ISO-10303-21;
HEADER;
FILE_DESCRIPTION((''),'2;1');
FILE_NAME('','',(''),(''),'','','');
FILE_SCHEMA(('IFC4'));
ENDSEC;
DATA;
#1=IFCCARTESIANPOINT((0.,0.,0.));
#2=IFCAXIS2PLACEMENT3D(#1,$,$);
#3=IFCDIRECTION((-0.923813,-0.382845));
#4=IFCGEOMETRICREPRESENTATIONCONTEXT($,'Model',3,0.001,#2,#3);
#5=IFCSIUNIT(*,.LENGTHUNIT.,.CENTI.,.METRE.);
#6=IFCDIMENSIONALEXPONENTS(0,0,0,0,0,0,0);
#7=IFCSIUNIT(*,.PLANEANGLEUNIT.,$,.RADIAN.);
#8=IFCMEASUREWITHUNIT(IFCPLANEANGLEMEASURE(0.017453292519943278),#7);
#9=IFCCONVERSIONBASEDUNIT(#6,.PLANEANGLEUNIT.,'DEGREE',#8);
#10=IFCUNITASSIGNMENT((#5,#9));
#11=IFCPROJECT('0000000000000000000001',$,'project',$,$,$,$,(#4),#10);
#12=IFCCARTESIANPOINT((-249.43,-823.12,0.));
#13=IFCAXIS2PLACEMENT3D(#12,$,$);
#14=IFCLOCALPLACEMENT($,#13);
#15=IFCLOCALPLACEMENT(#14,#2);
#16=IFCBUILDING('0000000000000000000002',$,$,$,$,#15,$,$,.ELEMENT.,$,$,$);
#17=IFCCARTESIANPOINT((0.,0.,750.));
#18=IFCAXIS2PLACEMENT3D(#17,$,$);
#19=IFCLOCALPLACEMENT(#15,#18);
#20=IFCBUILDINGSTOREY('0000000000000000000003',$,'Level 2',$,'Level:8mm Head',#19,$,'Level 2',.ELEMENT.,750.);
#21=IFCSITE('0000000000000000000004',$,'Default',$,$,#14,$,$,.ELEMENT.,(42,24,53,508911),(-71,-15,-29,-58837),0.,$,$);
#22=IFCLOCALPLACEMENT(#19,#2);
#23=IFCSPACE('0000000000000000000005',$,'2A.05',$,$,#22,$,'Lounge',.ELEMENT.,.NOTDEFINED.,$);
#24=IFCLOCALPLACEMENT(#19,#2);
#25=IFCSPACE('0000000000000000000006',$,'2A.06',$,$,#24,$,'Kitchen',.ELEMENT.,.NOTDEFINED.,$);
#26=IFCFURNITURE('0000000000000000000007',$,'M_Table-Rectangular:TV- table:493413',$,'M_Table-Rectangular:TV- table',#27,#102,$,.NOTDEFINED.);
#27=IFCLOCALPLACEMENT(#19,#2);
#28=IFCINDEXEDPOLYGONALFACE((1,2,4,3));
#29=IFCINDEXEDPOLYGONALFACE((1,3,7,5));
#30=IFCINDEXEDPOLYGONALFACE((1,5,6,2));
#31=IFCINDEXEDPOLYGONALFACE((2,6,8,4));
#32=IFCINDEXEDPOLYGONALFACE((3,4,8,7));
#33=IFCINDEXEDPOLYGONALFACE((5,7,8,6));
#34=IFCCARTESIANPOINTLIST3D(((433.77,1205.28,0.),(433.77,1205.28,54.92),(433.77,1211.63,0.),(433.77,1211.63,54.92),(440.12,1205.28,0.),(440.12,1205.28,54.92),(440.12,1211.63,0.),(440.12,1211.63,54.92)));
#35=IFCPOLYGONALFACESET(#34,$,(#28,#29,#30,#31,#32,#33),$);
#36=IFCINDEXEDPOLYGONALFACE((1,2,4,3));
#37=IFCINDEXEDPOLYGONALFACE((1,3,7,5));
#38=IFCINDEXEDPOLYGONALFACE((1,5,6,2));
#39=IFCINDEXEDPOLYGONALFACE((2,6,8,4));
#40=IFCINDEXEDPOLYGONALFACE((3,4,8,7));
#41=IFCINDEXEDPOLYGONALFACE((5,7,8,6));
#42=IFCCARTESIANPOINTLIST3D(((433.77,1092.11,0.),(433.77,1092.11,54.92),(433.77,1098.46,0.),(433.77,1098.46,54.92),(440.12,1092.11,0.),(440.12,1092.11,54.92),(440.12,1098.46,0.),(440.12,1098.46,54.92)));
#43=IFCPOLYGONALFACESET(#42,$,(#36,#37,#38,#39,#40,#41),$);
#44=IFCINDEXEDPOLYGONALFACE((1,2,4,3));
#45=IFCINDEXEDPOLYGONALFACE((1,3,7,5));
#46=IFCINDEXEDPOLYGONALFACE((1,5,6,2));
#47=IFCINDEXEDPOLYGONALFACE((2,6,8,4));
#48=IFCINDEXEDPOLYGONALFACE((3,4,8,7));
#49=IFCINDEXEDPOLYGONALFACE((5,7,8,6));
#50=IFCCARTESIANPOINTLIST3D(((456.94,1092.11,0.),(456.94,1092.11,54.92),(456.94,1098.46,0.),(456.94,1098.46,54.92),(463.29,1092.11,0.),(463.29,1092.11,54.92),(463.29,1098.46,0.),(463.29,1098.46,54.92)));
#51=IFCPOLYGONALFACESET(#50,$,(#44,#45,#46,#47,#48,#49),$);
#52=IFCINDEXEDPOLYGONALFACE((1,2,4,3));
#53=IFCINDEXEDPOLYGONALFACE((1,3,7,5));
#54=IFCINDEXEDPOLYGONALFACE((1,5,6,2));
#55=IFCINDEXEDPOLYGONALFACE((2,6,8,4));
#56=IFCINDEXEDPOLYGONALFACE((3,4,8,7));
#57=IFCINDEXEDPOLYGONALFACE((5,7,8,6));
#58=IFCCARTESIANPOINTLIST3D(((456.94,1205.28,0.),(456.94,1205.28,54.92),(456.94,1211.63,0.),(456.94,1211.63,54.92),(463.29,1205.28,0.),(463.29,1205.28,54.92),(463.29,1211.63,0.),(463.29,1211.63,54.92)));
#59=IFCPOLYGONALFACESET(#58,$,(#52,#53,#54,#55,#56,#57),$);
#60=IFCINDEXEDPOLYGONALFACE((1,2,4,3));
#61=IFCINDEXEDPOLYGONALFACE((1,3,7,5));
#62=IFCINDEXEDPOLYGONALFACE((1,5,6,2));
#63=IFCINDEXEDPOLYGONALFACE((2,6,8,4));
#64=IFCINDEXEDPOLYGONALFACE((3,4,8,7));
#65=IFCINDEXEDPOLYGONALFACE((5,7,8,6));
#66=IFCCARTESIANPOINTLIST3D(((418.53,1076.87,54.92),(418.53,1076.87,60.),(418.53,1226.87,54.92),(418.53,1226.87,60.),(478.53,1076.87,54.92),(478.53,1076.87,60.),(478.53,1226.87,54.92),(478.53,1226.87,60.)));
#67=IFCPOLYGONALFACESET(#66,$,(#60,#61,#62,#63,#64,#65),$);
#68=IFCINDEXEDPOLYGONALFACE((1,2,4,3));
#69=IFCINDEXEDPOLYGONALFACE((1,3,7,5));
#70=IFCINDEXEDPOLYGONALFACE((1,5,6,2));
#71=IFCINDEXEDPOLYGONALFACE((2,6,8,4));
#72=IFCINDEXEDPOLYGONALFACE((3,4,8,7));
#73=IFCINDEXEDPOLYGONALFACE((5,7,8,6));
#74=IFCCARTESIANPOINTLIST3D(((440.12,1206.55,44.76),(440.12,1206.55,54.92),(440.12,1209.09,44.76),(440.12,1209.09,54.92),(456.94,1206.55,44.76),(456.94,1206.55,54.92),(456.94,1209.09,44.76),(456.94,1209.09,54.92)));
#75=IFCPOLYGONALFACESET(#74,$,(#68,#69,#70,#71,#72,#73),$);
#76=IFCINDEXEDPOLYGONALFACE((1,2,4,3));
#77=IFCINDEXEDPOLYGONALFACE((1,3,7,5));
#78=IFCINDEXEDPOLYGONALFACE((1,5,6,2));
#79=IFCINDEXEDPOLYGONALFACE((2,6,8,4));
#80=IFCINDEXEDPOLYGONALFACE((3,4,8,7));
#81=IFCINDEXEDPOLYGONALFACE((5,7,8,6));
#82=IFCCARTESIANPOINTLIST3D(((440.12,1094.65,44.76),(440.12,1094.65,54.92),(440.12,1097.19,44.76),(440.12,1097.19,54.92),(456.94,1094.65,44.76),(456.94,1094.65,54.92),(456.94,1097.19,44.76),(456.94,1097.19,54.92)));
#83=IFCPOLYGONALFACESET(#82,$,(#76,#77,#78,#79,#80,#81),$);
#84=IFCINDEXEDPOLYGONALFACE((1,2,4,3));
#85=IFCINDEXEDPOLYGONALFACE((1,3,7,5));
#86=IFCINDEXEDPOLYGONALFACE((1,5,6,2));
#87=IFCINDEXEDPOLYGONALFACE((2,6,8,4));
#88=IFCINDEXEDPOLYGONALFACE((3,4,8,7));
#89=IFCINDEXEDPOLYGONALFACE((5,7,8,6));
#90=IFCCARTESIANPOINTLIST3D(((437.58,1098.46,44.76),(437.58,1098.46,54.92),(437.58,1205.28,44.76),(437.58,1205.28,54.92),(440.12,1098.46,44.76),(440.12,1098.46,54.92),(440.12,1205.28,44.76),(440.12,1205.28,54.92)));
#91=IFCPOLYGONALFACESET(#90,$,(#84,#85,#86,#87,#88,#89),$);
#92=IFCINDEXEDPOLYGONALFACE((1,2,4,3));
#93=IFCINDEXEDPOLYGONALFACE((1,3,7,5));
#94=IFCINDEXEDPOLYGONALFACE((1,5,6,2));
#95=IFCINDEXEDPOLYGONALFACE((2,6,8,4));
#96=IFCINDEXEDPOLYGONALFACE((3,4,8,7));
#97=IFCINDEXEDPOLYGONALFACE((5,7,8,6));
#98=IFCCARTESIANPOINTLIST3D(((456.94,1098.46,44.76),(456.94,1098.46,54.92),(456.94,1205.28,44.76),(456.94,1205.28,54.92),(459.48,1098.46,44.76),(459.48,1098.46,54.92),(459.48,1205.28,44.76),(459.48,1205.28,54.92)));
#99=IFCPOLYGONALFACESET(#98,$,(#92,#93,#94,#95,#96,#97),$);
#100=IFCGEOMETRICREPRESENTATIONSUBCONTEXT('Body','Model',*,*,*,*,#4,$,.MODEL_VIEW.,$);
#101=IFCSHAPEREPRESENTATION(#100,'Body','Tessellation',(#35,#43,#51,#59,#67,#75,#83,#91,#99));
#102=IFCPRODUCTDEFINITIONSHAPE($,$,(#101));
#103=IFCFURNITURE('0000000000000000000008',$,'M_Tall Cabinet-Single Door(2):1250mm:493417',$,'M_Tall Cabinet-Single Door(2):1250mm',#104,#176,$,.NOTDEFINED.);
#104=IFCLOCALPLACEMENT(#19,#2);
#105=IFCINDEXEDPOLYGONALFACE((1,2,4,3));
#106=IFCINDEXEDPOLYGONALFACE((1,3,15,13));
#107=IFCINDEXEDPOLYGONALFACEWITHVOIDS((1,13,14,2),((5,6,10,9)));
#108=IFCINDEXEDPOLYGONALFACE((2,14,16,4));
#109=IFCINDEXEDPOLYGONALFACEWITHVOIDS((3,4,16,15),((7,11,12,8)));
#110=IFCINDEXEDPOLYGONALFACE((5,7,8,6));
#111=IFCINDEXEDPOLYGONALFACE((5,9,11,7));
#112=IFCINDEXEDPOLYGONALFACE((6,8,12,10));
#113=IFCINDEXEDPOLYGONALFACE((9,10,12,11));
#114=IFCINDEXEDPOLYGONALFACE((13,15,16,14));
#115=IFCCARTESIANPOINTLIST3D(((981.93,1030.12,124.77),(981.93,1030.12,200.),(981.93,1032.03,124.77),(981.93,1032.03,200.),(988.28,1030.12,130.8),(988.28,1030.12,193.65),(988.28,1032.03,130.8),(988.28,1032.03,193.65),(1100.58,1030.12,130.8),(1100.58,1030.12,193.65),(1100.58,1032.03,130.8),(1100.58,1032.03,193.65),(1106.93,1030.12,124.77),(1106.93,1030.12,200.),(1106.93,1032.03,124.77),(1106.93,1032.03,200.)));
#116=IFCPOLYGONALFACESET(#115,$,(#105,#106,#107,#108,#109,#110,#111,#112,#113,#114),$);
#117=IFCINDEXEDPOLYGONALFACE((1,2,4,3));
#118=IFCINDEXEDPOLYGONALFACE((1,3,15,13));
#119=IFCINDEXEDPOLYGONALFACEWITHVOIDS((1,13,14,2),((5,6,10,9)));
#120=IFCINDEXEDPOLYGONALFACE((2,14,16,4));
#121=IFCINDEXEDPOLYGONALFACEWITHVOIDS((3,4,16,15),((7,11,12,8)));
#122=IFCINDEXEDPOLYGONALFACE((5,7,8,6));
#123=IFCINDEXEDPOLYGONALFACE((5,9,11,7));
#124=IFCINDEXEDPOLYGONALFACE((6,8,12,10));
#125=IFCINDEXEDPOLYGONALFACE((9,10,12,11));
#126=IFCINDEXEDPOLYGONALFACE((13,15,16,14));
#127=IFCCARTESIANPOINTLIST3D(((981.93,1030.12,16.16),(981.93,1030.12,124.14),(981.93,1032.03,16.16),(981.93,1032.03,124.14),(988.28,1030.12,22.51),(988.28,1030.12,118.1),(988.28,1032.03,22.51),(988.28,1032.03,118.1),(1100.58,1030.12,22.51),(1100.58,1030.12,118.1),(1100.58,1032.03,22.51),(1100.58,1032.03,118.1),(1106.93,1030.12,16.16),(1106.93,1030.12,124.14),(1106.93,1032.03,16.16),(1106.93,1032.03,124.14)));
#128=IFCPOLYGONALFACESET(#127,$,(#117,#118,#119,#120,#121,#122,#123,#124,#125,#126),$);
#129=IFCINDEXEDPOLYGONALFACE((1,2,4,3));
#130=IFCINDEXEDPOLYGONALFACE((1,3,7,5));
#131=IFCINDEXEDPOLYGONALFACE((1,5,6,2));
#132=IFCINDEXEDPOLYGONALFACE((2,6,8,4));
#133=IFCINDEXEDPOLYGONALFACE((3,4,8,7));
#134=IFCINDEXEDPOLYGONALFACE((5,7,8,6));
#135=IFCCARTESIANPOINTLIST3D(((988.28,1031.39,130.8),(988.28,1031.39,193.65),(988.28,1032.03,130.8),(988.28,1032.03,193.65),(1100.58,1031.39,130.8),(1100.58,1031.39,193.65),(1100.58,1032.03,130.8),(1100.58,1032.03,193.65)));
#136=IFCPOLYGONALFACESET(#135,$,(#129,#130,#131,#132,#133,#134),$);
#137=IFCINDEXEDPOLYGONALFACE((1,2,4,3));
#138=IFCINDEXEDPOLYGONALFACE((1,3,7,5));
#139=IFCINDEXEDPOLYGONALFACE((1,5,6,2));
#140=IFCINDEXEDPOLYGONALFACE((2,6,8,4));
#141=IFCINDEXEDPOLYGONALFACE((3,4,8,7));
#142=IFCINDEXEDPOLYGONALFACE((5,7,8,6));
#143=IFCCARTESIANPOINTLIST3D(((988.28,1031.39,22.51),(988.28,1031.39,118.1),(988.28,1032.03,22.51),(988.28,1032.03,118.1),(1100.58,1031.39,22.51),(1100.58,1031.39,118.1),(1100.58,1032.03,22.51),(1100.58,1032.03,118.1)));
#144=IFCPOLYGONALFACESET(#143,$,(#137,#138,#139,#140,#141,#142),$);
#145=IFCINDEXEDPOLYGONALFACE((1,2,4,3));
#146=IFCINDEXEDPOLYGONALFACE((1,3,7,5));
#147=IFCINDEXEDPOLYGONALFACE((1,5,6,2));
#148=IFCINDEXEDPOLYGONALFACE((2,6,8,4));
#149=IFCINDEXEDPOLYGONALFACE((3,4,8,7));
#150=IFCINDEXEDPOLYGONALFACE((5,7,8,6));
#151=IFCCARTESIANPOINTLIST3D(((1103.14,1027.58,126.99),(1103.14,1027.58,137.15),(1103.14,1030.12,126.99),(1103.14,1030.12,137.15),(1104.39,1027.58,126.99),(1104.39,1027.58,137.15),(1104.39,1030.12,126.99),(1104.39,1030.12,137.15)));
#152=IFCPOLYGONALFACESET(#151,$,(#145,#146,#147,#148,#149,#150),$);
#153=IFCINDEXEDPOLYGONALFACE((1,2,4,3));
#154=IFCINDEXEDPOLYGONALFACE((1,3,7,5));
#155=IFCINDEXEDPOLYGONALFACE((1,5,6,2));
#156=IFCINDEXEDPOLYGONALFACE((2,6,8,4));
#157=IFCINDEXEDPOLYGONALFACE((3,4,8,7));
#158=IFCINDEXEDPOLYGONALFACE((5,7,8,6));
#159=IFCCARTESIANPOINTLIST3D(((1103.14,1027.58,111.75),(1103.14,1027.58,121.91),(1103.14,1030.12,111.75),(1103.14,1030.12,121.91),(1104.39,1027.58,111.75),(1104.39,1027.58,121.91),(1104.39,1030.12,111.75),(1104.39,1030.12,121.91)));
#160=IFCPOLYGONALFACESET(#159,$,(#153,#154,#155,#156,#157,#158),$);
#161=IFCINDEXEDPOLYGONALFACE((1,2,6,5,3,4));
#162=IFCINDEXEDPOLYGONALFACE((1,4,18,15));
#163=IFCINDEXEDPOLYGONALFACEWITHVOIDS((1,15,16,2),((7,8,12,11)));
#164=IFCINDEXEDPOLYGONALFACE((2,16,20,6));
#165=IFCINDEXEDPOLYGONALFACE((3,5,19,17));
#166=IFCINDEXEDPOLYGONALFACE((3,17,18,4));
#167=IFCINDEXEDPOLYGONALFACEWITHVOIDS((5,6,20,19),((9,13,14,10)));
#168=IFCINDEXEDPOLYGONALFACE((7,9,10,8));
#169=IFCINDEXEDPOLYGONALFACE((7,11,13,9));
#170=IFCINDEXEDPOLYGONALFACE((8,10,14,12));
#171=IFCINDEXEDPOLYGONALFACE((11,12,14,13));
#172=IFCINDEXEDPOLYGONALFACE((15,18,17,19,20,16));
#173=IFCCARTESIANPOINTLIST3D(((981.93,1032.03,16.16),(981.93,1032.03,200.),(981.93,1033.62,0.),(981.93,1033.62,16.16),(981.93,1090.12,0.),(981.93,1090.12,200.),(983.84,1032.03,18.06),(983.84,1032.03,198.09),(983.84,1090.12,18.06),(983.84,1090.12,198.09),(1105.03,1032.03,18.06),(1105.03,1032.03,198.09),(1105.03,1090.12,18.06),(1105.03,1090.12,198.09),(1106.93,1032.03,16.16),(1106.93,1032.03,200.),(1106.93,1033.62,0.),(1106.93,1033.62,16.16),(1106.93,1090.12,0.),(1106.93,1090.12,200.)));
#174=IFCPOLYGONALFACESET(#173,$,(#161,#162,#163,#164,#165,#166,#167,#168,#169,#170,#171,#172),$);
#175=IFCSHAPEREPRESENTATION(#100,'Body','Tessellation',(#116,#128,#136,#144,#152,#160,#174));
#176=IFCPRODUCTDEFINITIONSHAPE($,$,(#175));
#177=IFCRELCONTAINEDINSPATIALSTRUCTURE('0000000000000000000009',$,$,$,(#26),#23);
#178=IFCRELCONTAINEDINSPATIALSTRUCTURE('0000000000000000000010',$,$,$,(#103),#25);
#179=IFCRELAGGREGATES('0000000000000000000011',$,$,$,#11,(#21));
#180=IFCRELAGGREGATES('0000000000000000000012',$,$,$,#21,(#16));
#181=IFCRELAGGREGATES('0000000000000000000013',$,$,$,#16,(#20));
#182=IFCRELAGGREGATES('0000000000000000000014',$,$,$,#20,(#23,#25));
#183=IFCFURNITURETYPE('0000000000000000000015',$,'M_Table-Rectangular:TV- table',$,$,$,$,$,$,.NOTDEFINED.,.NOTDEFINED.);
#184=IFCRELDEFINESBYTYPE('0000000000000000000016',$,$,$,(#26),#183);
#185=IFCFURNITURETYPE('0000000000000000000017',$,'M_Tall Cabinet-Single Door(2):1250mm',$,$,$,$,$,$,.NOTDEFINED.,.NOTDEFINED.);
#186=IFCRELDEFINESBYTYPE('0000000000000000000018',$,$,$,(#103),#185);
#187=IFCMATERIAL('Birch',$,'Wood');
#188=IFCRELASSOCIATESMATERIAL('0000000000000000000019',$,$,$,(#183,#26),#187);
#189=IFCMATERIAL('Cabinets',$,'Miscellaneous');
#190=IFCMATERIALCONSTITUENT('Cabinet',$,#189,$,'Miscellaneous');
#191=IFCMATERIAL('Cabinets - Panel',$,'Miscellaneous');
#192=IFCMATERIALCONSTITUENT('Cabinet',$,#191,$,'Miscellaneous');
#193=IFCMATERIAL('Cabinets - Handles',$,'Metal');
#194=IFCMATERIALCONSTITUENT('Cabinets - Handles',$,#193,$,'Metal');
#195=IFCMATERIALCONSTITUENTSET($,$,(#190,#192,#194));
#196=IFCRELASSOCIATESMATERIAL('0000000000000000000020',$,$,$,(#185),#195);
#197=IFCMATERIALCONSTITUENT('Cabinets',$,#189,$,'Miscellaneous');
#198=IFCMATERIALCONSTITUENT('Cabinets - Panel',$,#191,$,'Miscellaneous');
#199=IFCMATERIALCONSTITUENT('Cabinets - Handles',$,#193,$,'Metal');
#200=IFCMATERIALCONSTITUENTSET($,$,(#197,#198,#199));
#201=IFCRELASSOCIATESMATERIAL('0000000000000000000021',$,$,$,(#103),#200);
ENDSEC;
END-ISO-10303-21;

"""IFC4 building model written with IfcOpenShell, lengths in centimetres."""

from ifc_helpers import new_model, entity, si_unit, converted_unit, direction, frame, origin, place, context, subcontext, project, spatial, indexed_curve, outline, extrude, source, transform, mapped, material, constituent, constituent_set, type_object, type_shapes, element, save


model = new_model("IFC4")

# Units and contexts
model_context = context("Model", 3, precision=0.001, world=origin(), true_north=direction((-0.923813, -0.382845)))
body_context = subcontext(model_context, "Body", "Model", "MODEL_VIEW")
ifc_project = project(units=[si_unit("LENGTHUNIT", "METRE", prefix="CENTI"), converted_unit("PLANEANGLEUNIT", "DEGREE", entity("IfcPlaneAngleMeasure", 0.017453292519943278), si_unit("PLANEANGLEUNIT", "RADIAN"), dimensions=[0, 0, 0, 0, 0, 0, 0])], contexts=[model_context])

# Site, building, storey
site_placement = place(None, frame((-249.43, -823.12, 0.0)))
site = spatial("IfcSite", under=ifc_project, at=site_placement, Name="Default", CompositionType="ELEMENT", RefLatitude=(42, 24, 53, 508911), RefLongitude=(-71, -15, -29, -58837), RefElevation=0.0)
building_placement = place(site_placement, origin())
building = spatial("IfcBuilding", under=site, at=building_placement, CompositionType="ELEMENT")
storey_placement = place(building_placement, frame((0.0, 0.0, 750.0)))
storey = spatial("IfcBuildingStorey", under=building, at=storey_placement, Name="Level 2", ObjectType="Level:8mm Head", LongName="Level 2", CompositionType="ELEMENT", Elevation=750.0)

# Shared definitions
space_1_placement = place(storey_placement, origin())
space_1 = spatial("IfcSpace", under=storey, at=space_1_placement, Name="2A.05", LongName="Lounge", CompositionType="ELEMENT", PredefinedType="NOTDEFINED")

# Furniture
ifc_material_1 = material(Name="Birch", Category="Wood")
furniture_type_1 = type_object("IfcFurnitureType", Name="M_Table-Rectangular:TV- table", AssemblyPlace="NOTDEFINED", PredefinedType="NOTDEFINED", material=ifc_material_1)
shared_shape_1 = source(origin(), body_context, "Body", "SweptSolid", [
    extrude(outline(indexed_curve([(-3.18, -3.18), (3.18, -3.18), (3.18, 3.18), (-3.18, 3.18), (-3.18, -3.18)], self_intersect=False)), frame((56.58, 11.59, 0.0), z_axis=(0.0, 0.0, 1.0), x_axis=(0.0, -1.0, 0.0)), (0.0, 0.0, 1.0), 54.92),
    extrude(outline(indexed_curve([(-3.17, -3.18), (3.17, -3.18), (3.17, 3.18), (-3.17, 3.18), (-3.17, -3.18)], self_intersect=False)), frame((-56.58, 11.59, 0.0), z_axis=(0.0, 0.0, 1.0), x_axis=(-1.0, 0.0, 0.0)), (0.0, 0.0, 1.0), 54.92),
    extrude(outline(indexed_curve([(-3.17, -3.17), (3.17, -3.17), (3.17, 3.17), (-3.17, 3.17), (-3.17, -3.17)], self_intersect=False)), frame((-56.58, -11.59, 0.0), z_axis=(0.0, 0.0, 1.0), x_axis=(0.0, 1.0, 0.0)), (0.0, 0.0, 1.0), 54.92),
    extrude(outline(indexed_curve([(-3.18, -3.17), (3.18, -3.17), (3.18, 3.17), (-3.18, 3.17), (-3.18, -3.17)], self_intersect=False)), frame((56.58, -11.59, 0.0)), (0.0, 0.0, 1.0), 54.92),
    extrude(outline(indexed_curve([(-75.0, -30.0), (75.0, -30.0), (75.0, 30.0), (-75.0, 30.0), (-75.0, -30.0)], self_intersect=False)), frame((0.0, 0.0, 54.92), z_axis=(0.0, 0.0, 1.0), x_axis=(-1.0, 0.0, 0.0)), (0.0, 0.0, 1.0), 5.08),
    extrude(outline(indexed_curve([(-1.27, -8.41), (1.27, -8.41), (1.27, 8.41), (-1.27, 8.41), (-1.27, -8.41)], self_intersect=False)), frame((55.95, 0.0, 44.76)), (0.0, 0.0, 1.0), 10.16),
    extrude(outline(indexed_curve([(-8.41, -1.27), (8.41, -1.27), (8.41, 1.27), (-8.41, 1.27), (-8.41, -1.27)], self_intersect=False)), frame((-55.95, 0.0, 44.76), z_axis=(0.0, 0.0, 1.0), x_axis=(0.0, 1.0, 0.0)), (0.0, 0.0, 1.0), 10.16),
    extrude(outline(indexed_curve([(-53.41, -1.27), (53.41, -1.27), (53.41, 1.27), (-53.41, 1.27), (-53.41, -1.27)], self_intersect=False)), frame((0.0, 9.68, 44.76), z_axis=(0.0, 0.0, 1.0), x_axis=(-1.0, 0.0, 0.0)), (0.0, 0.0, 1.0), 10.16),
    extrude(outline(indexed_curve([(-1.27, -53.41), (1.27, -53.41), (1.27, 53.41), (-1.27, 53.41), (-1.27, -53.41)], self_intersect=False)), frame((0.0, -9.68, 44.76), z_axis=(0.0, 0.0, 1.0), x_axis=(0.0, 1.0, 0.0)), (0.0, 0.0, 1.0), 10.16),
])
type_shapes(furniture_type_1, [shared_shape_1])
furniture_1_placement = place(space_1_placement, frame((448.53, 1151.87, 0.0), z_axis=(0.0, 0.0, 1.0), x_axis=(0.0, 1.0, 0.0)))
element("IfcFurniture", 1, at=furniture_1_placement, inside=space_1, type_object=furniture_type_1, material=ifc_material_1, Name="M_Table-Rectangular:TV- table:493413", ObjectType="M_Table-Rectangular:TV- table", PredefinedType="NOTDEFINED", context=body_context, shape_type="MappedRepresentation", body=[
    mapped(shared_shape_1, transform((0.0, 0.0, 0.0), scale=1.0)),
])

# Shared definitions
space_2_placement = place(storey_placement, origin())
space_2 = spatial("IfcSpace", under=storey, at=space_2_placement, Name="2A.06", LongName="Kitchen", CompositionType="ELEMENT", PredefinedType="NOTDEFINED")

# Furniture, opening
ifc_material_2 = material(Name="Cabinets", Category="Miscellaneous")
ifc_constituent_1 = constituent(ifc_material_2, Name="Cabinets", Category="Miscellaneous")
ifc_material_3 = material(Name="Cabinets - Panel", Category="Miscellaneous")
ifc_constituent_2 = constituent(ifc_material_3, Name="Cabinets - Panel", Category="Miscellaneous")
ifc_material_4 = material(Name="Cabinets - Handles", Category="Metal")
ifc_constituent_3 = constituent(ifc_material_4, Name="Cabinets - Handles", Category="Metal")
ifc_constituent_set_1 = constituent_set(constituents=[ifc_constituent_1, ifc_constituent_2, ifc_constituent_3])
ifc_constituent_4 = constituent(ifc_material_2, Name="Cabinet", Category="Miscellaneous")
ifc_constituent_5 = constituent(ifc_material_3, Name="Cabinet", Category="Miscellaneous")
ifc_constituent_6 = constituent(ifc_material_4, Name="Cabinets - Handles", Category="Metal")
ifc_constituent_set_2 = constituent_set(constituents=[ifc_constituent_4, ifc_constituent_5, ifc_constituent_6])
furniture_type_2 = type_object("IfcFurnitureType", Name="M_Tall Cabinet-Single Door(2):1250mm", AssemblyPlace="NOTDEFINED", PredefinedType="NOTDEFINED", material=ifc_constituent_set_2)
shared_shape_2 = source(origin(), body_context, "Body", "SweptSolid", [
    extrude(outline(indexed_curve([(-0.95, -60.59), (0.95, -60.59), (0.95, 60.59), (-0.95, 60.59), (-0.95, -60.59)], self_intersect=False)), frame((1.87, -0.95, 18.06), z_axis=(0.0, 0.0, 1.0), x_axis=(0.0, 1.0, 0.0)), (0.0, 0.0, 1.0), 180.03),
    extrude(outline(indexed_curve([(-37.61, -62.5), (37.61, -62.5), (37.61, 62.5), (-37.61, 62.5), (-37.61, -62.5)], self_intersect=False), holes=[indexed_curve([(-31.26, -56.15), (-31.26, 56.15), (31.58, 56.15), (31.58, -56.15), (-31.26, -56.15)], self_intersect=False)]), frame((1.87, -60.0, 162.39), z_axis=(0.0, 1.0, 0.0), x_axis=(0.0, 0.0, -1.0)), (0.0, 0.0, 1.0), 1.91),
    extrude(outline(indexed_curve([(-62.5, -53.99), (62.5, -53.99), (62.5, 53.99), (-62.5, 53.99), (-62.5, -53.99)], self_intersect=False), holes=[indexed_curve([(-56.15, 47.96), (56.15, 47.96), (56.15, -47.64), (-56.15, -47.64), (-56.15, 47.96)], self_intersect=False)]), frame((1.87, -60.0, 70.15), z_axis=(0.0, 1.0, 0.0), x_axis=(-1.0, 0.0, 0.0)), (0.0, 0.0, 1.0), 1.91),
    extrude(outline(indexed_curve([(-0.32, -56.15), (0.32, -56.15), (0.32, 56.15), (-0.32, 56.15), (-0.32, -56.15)], self_intersect=False)), frame((1.87, -58.41, 130.8), z_axis=(0.0, 0.0, 1.0), x_axis=(0.0, 1.0, 0.0)), (0.0, 0.0, 1.0), 62.85),
    extrude(outline(indexed_curve([(-0.32, -56.15), (0.32, -56.15), (0.32, 56.15), (-0.32, 56.15), (-0.32, -56.15)], self_intersect=False)), frame((1.87, -58.41, 22.51), z_axis=(0.0, 0.0, 1.0), x_axis=(0.0, 1.0, 0.0)), (0.0, 0.0, 1.0), 95.6),
    extrude(outline(indexed_curve([(-1.27, -0.63), (1.27, -0.63), (1.27, 0.63), (-1.27, 0.63), (-1.27, -0.63)], self_intersect=False)), frame((61.21, -61.27, 126.99), z_axis=(0.0, 0.0, 1.0), x_axis=(0.0, 1.0, 0.0)), (0.0, 0.0, 1.0), 10.16),
    extrude(outline(indexed_curve([(-1.27, -0.63), (1.27, -0.63), (1.27, 0.63), (-1.27, 0.63), (-1.27, -0.63)], self_intersect=False)), frame((61.21, -61.27, 111.75), z_axis=(0.0, 0.0, 1.0), x_axis=(0.0, 1.0, 0.0)), (0.0, 0.0, 1.0), 10.16),
    extrude(outline(indexed_curve([(-19.9, 55.89), (-19.9, -127.95), (38.2, -127.95), (38.2, 72.05), (-18.3, 72.05), (-18.3, 55.89), (-19.9, 55.89)], self_intersect=False)), frame((-60.63, -38.2, 72.05), z_axis=(-1.0, 0.0, 0.0), x_axis=(0.0, 1.0, 0.0)), (0.0, 0.0, -1.0), 125.0),
])
type_shapes(furniture_type_2, [shared_shape_2])
furniture_2_placement = place(space_2_placement, frame((1042.56, 1090.12, 0.0)))
furniture_2 = element("IfcFurniture", 2, at=furniture_2_placement, inside=space_2, type_object=furniture_type_2, material=ifc_constituent_set_1, Name="M_Tall Cabinet-Single Door(2):1250mm:493417", ObjectType="M_Tall Cabinet-Single Door(2):1250mm", PredefinedType="NOTDEFINED", context=body_context, shape_type="MappedRepresentation", body=[
    mapped(shared_shape_2, transform((0.0, 0.0, 0.0), scale=1.0)),
])
opening_1_placement = place(storey_placement, frame((1042.56, 1090.12, 750.0)))
element("IfcOpeningElement", 3, at=opening_1_placement, cuts=furniture_2, PredefinedType="OPENING", context=body_context, shape_type="SweptSolid", body=[
    extrude(outline(indexed_curve([(-90.02, -60.59), (90.02, -60.59), (90.02, 60.59), (-90.02, 60.59), (-90.02, -60.59)], self_intersect=False)), frame((1.87, -58.09, -641.92), z_axis=(0.0, 1.0, 0.0), x_axis=(0.0, 0.0, -1.0)), (0.0, 0.0, 1.0), 58.09),
])

save(model, "model.ifc")
